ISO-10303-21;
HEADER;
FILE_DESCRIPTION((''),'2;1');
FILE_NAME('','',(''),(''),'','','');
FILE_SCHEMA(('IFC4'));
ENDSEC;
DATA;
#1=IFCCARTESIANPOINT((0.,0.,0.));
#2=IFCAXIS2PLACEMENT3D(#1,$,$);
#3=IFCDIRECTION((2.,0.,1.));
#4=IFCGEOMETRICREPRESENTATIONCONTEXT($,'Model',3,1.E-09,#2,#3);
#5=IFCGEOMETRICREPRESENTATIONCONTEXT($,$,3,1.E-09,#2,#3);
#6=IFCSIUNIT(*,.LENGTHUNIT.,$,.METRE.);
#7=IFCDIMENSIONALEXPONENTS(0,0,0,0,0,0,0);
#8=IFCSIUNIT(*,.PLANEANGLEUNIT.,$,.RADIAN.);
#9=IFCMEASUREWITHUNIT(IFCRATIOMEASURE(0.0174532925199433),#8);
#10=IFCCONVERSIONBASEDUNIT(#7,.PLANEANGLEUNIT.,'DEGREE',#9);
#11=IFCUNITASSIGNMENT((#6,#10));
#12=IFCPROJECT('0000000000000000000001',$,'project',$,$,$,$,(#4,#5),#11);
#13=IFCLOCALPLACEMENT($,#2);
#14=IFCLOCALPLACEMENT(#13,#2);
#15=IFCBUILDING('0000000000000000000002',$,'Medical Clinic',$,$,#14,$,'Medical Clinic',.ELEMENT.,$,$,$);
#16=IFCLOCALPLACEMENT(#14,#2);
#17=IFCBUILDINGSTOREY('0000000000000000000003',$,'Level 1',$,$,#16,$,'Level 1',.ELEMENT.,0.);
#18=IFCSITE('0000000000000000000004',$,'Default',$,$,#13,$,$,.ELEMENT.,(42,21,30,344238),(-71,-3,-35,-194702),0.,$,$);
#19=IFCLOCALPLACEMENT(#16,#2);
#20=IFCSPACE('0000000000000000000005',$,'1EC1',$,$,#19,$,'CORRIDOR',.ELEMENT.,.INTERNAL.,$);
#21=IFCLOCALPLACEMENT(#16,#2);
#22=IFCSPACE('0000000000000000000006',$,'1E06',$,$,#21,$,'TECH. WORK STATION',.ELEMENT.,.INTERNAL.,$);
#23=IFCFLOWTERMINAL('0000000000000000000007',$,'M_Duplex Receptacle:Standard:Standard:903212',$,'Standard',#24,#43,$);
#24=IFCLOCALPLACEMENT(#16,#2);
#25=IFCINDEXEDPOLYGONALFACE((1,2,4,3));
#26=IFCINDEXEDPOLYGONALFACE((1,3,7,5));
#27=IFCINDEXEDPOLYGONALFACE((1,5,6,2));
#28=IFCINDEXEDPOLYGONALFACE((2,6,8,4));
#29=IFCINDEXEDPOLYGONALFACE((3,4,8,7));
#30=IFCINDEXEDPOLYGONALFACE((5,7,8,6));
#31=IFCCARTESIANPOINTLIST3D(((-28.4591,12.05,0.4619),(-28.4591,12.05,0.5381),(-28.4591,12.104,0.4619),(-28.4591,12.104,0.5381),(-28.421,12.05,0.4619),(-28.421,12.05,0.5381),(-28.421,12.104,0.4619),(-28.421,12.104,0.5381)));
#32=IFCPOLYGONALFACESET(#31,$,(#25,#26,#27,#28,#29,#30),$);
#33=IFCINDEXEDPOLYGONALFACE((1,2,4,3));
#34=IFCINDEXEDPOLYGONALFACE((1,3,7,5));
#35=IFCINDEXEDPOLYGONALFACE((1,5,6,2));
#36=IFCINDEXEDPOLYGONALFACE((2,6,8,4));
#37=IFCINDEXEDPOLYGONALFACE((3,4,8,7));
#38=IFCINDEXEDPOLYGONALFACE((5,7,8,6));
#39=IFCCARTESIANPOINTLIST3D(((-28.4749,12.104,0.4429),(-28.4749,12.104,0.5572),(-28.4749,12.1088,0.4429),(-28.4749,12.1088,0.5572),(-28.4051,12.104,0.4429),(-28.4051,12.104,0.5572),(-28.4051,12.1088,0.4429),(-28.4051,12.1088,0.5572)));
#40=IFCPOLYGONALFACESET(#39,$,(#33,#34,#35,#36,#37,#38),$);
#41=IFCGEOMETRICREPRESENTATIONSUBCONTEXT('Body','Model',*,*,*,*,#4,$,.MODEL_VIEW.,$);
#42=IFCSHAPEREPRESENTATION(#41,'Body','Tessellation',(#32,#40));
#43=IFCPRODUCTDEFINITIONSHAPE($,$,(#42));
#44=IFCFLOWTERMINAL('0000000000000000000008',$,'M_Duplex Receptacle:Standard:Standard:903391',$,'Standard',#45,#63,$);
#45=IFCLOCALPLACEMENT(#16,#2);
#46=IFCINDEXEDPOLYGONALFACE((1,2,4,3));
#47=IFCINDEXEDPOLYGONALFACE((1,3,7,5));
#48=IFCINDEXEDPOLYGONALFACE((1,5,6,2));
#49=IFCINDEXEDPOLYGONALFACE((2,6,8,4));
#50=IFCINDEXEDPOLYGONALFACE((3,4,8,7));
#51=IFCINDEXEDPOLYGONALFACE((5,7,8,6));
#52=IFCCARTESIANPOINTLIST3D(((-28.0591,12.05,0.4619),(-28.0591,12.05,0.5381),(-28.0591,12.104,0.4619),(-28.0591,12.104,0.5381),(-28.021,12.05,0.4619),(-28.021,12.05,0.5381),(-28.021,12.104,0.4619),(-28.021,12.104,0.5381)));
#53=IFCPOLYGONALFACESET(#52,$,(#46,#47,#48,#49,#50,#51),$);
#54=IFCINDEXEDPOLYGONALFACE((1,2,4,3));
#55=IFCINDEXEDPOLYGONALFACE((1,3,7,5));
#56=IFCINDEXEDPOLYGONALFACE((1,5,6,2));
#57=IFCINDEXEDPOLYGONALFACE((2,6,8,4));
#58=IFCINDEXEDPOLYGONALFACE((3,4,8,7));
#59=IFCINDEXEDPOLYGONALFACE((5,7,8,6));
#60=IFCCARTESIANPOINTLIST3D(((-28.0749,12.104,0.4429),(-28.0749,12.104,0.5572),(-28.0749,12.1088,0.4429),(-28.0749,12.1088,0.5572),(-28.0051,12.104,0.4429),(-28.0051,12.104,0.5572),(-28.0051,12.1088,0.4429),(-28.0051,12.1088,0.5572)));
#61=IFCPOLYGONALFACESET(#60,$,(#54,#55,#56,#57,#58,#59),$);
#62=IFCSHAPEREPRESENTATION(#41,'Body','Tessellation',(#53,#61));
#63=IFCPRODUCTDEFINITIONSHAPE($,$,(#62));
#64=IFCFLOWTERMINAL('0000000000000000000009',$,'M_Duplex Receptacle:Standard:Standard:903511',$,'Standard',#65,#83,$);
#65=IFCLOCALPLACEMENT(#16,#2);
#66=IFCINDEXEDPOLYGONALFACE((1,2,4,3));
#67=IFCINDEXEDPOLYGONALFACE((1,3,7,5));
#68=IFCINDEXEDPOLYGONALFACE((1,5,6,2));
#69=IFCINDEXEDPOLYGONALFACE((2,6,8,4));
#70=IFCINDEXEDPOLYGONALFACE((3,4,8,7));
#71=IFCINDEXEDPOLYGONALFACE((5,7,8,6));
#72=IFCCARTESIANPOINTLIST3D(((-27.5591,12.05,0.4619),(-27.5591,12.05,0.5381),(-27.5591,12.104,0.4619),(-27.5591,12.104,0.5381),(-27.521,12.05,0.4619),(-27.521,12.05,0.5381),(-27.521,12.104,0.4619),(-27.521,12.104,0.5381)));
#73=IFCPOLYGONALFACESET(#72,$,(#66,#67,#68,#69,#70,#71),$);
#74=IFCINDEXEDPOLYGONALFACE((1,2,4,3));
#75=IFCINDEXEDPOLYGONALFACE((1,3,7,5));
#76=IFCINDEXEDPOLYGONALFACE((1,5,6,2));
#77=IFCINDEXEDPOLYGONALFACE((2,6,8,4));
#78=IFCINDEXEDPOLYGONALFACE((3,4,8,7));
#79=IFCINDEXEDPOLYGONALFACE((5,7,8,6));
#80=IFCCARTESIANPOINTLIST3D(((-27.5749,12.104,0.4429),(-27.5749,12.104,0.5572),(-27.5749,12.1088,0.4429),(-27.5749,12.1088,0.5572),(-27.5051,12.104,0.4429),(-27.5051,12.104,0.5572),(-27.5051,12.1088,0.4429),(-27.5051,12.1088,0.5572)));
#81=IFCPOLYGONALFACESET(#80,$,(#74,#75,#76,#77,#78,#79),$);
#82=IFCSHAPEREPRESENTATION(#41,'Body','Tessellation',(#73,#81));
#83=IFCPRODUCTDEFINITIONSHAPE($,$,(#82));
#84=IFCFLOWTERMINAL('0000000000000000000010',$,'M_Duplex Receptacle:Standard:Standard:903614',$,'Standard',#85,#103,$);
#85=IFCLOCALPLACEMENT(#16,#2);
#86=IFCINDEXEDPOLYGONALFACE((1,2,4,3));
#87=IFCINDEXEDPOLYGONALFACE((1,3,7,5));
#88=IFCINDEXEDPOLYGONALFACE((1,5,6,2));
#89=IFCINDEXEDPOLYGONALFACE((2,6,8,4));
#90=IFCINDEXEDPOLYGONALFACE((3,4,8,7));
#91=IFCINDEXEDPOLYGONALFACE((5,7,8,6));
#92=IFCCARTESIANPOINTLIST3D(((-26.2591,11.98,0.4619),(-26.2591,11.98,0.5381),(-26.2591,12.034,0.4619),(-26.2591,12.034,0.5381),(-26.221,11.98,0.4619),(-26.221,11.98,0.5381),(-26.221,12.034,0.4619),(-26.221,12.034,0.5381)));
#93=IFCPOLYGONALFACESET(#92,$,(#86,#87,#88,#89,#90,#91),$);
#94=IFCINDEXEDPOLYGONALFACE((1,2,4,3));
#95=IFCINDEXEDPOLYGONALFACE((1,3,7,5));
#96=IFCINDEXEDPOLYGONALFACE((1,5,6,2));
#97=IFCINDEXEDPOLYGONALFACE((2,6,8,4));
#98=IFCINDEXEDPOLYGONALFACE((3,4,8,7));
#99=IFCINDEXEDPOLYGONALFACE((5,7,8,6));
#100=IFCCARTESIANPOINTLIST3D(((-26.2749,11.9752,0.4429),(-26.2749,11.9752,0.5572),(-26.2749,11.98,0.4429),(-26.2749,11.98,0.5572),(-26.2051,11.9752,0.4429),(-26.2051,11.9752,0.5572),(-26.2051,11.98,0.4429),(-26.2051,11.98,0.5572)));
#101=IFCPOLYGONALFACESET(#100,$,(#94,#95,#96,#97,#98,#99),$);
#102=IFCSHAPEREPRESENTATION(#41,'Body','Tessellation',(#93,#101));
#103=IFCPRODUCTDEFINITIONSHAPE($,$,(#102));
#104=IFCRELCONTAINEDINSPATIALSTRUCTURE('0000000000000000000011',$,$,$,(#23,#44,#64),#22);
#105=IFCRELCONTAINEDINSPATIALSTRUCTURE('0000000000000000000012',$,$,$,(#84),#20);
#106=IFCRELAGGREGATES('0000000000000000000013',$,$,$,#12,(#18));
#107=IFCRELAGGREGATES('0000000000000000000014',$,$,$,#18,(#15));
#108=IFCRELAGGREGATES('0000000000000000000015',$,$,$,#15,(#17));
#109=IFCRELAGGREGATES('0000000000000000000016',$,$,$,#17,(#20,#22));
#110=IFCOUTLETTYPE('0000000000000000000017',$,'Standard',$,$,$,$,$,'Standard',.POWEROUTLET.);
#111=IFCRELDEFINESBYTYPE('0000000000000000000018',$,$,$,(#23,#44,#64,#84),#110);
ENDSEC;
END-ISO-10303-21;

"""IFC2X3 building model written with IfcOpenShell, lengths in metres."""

from ifc_helpers import new_model, entity, si_unit, converted_unit, direction, frame, frame_2d, origin, origin_2d_with_axis, place, context, subcontext, project, spatial, rectangle, extrude, source, transform, mapped, type_object, type_shapes, element, save


model = new_model("IFC2X3")

# Units and contexts
model_context = context("Model", 3, precision=1e-09, world=origin(), true_north=direction((2.0, 0.0, 1.0)))
context_of_model = context(None, 3, precision=1e-09, world=origin(), true_north=direction((2.0, 0.0, 1.0)))
body_context = subcontext(model_context, "Body", "Model", "MODEL_VIEW")
ifc_project = project(units=[si_unit("LENGTHUNIT", "METRE"), converted_unit("PLANEANGLEUNIT", "DEGREE", entity("IfcRatioMeasure", 0.0174532925199433), si_unit("PLANEANGLEUNIT", "RADIAN"), dimensions=[0, 0, 0, 0, 0, 0, 0])], contexts=[model_context, context_of_model])

# Site, building, storey
site_placement = place(None, origin())
site = spatial("IfcSite", under=ifc_project, at=site_placement, Name="Default", CompositionType="ELEMENT", RefLatitude=(42, 21, 30, 344238), RefLongitude=(-71, -3, -35, -194702), RefElevation=0.0)
building_placement = place(site_placement, origin())
building = spatial("IfcBuilding", under=site, at=building_placement, Name="Medical Clinic", LongName="Medical Clinic", CompositionType="ELEMENT")
storey_placement = place(building_placement, origin())
storey = spatial("IfcBuildingStorey", under=building, at=storey_placement, Name="Level 1", LongName="Level 1", CompositionType="ELEMENT", Elevation=0.0)

# Shared definitions
space_1_placement = place(storey_placement, origin())
space_1 = spatial("IfcSpace", under=storey, at=space_1_placement, Name="1EC1", LongName="CORRIDOR", CompositionType="ELEMENT", InteriorOrExteriorSpace="INTERNAL")

# Shared definitions
space_2_placement = place(storey_placement, origin())
space_2 = spatial("IfcSpace", under=storey, at=space_2_placement, Name="1E06", LongName="TECH. WORK STATION", CompositionType="ELEMENT", InteriorOrExteriorSpace="INTERNAL")

# Shared definitions
outlet_type = type_object("IfcOutletType", Name="Standard", ElementType="Standard", PredefinedType="POWEROUTLET")
shared_shape_1 = source(origin(), body_context, "Body", "SweptSolid", [
    extrude(rectangle(XDim=0.0381, YDim=0.0762, at=origin_2d_with_axis()), frame((0.0, 0.0, -0.054), z_axis=(0.0, 0.0, 1.0), x_axis=(-1.0, 0.0, 0.0)), (0.0, 0.0, 1.0), 0.054),
    extrude(rectangle(XDim=0.0698, YDim=0.1143, at=frame_2d((0.0, 0.0), x_axis=(1.0, 0.0))), frame((0.0, 0.0, 0.0), z_axis=(0.0, 0.0, 1.0), x_axis=(-1.0, 0.0, 0.0)), (0.0, 0.0, 1.0), 0.0048),
])
type_shapes(outlet_type, [shared_shape_1])

# Flow terminals
for number, where, z_axis, x_axis, name in (
    (1, (-28.44, 12.104, 0.5), (0.0, 1.0, 0.0), (-1.0, 0.0, 0.0), "M_Duplex Receptacle:Standard:Standard:903212"),
    (2, (-28.04, 12.104, 0.5), (0.0, 1.0, 0.0), (-1.0, 0.0, 0.0), "M_Duplex Receptacle:Standard:Standard:903391"),
    (3, (-27.54, 12.104, 0.5), (0.0, 1.0, 0.0), (-1.0, 0.0, 0.0), "M_Duplex Receptacle:Standard:Standard:903511"),
):
    element("IfcFlowTerminal", number, at=place(space_2_placement, frame(where, z_axis=z_axis, x_axis=x_axis)), inside=space_2, type_object=outlet_type, Name=name, ObjectType="Standard", context=body_context, shape_type="MappedRepresentation", body=[
        mapped(shared_shape_1, transform((0.0, 0.0, 0.0), scale=1.0)),
    ])
flow_terminal_1_placement = place(space_1_placement, frame((-26.24, 11.98, 0.5), z_axis=(0.0, -1.0, 0.0), x_axis=(1.0, 0.0, 0.0)))
element("IfcFlowTerminal", 4, at=flow_terminal_1_placement, inside=space_1, type_object=outlet_type, Name="M_Duplex Receptacle:Standard:Standard:903614", ObjectType="Standard", context=body_context, shape_type="MappedRepresentation", body=[
    mapped(shared_shape_1, transform((0.0, 0.0, 0.0), scale=1.0)),
])

save(model, "model.ifc")
